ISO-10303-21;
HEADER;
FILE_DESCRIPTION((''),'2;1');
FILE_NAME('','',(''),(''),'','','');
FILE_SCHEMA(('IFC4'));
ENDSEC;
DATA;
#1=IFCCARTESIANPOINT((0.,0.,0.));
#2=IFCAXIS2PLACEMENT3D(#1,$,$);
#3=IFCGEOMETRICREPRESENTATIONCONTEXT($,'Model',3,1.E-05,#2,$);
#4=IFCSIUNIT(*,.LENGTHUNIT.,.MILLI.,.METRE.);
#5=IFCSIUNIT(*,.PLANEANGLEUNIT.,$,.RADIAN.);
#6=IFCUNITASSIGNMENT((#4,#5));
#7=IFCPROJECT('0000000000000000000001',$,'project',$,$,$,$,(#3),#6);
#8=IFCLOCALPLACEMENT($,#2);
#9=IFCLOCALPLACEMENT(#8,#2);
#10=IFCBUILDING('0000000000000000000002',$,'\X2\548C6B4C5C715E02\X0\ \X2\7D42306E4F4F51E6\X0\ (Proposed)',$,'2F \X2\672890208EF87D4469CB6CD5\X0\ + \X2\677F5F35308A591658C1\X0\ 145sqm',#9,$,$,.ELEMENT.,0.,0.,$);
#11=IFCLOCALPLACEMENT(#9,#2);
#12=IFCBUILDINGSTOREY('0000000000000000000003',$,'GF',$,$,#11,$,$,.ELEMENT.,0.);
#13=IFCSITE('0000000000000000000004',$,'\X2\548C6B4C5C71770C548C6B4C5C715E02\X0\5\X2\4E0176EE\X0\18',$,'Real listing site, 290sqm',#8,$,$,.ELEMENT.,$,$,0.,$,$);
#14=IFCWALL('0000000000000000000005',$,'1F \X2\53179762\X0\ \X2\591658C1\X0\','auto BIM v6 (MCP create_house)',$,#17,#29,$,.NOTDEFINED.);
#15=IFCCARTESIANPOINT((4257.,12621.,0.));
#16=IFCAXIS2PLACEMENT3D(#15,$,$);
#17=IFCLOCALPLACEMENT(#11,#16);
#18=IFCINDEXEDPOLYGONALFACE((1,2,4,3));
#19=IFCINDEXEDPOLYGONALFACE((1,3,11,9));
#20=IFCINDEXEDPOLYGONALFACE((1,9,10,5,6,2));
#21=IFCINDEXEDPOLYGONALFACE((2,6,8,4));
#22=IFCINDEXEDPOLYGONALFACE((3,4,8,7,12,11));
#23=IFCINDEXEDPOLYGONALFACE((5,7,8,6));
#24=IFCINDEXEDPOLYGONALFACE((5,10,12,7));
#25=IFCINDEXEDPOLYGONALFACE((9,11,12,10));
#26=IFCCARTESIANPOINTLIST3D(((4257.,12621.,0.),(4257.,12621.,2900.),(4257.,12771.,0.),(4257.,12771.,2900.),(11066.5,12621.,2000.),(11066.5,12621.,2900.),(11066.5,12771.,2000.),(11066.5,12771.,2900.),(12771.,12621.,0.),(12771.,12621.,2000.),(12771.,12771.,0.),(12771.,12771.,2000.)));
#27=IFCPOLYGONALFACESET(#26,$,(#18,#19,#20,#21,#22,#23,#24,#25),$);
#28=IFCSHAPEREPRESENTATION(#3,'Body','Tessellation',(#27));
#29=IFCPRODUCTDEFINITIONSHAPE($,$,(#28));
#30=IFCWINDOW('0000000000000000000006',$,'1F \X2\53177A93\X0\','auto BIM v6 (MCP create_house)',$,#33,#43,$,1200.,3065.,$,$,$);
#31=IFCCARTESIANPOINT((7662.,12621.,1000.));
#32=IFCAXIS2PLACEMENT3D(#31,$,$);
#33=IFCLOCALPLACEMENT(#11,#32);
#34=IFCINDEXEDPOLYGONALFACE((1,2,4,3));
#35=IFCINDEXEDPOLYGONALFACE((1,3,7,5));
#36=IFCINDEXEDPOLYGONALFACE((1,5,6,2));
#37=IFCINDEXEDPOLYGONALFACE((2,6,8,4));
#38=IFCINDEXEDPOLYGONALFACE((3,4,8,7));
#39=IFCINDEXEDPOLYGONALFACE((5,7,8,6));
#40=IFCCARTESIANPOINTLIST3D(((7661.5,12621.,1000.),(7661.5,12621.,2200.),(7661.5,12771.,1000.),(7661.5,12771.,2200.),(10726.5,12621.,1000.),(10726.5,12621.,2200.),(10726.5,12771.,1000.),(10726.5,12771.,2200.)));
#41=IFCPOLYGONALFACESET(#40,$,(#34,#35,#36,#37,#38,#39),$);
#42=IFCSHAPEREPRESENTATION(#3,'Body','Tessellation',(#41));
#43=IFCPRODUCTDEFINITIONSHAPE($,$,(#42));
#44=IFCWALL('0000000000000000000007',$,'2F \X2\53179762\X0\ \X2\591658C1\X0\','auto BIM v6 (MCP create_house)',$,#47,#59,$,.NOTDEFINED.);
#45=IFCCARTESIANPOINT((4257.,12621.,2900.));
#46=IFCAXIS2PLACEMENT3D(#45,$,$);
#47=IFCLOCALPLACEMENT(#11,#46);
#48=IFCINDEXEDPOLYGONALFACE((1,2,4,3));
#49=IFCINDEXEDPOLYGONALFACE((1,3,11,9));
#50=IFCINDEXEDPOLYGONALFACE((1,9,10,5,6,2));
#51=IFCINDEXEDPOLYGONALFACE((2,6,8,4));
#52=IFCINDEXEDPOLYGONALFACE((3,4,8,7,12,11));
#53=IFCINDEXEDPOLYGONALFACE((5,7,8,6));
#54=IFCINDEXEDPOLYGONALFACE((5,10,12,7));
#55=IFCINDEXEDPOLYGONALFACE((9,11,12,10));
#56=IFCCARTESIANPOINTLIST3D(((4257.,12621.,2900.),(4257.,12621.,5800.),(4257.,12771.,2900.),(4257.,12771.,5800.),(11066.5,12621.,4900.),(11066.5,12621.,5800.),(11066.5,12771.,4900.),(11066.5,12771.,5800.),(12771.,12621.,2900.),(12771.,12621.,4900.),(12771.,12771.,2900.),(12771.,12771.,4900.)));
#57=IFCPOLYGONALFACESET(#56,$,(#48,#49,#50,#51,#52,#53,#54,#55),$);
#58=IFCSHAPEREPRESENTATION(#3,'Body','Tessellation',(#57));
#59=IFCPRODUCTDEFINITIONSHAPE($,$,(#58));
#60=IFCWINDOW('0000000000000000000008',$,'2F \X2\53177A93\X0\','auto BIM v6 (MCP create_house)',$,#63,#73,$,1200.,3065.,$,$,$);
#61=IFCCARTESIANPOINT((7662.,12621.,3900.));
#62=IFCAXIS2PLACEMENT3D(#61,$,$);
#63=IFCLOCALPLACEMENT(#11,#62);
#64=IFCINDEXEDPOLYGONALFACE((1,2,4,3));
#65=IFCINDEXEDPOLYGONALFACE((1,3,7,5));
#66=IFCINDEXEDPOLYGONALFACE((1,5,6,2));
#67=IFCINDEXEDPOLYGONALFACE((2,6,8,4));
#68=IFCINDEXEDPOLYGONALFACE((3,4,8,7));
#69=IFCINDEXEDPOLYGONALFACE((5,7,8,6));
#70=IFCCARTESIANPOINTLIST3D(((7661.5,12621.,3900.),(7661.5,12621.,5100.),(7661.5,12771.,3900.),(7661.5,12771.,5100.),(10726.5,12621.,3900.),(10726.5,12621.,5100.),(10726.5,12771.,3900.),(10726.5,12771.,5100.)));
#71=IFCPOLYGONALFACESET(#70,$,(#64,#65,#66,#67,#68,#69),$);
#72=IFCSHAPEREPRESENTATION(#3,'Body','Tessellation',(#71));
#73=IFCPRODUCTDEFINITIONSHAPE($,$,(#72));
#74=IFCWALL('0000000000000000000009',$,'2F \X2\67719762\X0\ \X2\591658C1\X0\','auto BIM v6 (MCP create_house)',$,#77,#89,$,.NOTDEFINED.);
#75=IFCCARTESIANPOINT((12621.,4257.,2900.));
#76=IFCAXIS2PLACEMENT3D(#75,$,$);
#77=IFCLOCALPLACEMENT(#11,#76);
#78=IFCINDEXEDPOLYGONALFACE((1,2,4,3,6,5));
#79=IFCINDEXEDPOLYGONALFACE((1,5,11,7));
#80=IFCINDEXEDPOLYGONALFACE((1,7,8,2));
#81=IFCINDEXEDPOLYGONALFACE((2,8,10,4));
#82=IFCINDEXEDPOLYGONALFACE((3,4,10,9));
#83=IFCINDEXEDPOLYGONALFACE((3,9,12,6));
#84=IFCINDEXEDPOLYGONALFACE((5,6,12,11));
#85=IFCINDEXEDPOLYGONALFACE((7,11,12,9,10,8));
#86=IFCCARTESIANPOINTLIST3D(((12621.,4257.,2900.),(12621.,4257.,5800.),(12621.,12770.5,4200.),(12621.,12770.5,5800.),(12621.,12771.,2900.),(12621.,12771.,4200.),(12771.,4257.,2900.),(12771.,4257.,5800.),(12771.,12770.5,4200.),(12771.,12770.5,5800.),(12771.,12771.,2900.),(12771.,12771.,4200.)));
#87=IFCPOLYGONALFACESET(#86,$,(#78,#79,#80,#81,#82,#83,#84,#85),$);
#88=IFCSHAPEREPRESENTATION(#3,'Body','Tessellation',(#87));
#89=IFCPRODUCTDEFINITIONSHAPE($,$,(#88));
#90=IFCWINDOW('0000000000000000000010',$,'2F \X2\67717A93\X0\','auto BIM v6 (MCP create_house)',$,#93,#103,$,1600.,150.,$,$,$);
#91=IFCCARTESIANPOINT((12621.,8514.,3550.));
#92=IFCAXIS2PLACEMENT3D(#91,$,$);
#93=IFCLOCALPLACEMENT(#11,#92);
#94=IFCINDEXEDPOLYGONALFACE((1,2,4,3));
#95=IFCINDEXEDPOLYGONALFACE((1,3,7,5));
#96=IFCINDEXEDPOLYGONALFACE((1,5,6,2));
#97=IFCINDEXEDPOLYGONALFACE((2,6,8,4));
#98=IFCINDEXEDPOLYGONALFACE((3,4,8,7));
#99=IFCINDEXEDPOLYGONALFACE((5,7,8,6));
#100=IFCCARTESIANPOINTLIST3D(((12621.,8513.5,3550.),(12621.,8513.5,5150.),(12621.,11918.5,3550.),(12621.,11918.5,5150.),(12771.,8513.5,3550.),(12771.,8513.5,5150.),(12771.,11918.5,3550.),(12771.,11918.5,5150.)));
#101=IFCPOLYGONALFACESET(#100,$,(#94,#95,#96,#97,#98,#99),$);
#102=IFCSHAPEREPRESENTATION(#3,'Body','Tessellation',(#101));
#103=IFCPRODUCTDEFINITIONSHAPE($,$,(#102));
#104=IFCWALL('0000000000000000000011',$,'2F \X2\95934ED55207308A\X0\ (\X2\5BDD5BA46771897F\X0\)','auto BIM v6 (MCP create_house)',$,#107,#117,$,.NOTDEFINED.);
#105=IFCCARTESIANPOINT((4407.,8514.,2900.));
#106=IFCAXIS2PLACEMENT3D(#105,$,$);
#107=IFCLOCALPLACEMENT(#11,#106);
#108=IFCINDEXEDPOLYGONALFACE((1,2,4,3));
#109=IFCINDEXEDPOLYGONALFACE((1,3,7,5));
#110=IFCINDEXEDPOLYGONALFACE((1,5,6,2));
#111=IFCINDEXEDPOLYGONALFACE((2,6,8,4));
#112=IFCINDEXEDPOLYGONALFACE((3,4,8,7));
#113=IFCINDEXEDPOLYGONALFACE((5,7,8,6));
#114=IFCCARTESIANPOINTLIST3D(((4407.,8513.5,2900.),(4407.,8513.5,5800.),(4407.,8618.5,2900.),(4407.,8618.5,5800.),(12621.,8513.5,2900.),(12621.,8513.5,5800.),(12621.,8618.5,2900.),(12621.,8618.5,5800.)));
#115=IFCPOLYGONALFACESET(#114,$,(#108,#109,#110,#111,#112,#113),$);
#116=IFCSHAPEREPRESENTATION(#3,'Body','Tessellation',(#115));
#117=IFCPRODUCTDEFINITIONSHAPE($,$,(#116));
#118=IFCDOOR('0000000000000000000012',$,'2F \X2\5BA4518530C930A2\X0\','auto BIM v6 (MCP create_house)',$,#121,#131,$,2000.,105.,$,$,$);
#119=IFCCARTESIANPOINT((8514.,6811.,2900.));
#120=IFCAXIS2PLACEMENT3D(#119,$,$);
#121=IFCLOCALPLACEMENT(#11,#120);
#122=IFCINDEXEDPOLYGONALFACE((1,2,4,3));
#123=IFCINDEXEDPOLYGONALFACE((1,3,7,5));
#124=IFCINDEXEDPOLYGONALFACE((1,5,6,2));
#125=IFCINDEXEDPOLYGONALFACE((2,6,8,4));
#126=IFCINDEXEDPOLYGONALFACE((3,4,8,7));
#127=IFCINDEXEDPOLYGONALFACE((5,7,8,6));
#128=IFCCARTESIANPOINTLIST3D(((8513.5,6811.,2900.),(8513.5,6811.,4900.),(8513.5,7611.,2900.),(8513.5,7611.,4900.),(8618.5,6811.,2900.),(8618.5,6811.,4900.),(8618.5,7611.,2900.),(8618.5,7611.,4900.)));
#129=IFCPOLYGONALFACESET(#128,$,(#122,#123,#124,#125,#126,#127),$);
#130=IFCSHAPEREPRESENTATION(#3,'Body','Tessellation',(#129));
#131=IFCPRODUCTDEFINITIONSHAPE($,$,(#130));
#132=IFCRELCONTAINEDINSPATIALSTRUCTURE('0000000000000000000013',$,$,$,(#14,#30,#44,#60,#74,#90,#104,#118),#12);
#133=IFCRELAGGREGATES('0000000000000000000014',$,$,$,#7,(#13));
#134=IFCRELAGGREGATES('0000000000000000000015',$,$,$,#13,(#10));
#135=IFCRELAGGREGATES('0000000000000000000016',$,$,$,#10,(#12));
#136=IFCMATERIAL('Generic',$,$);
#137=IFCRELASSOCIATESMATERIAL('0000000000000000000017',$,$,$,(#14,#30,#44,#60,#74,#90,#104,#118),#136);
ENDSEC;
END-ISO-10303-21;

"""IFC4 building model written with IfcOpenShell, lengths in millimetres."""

from ifc_helpers import new_model, si_unit, frame, frame_2d, origin, place, context, project, spatial, rectangle, extrude, material, element, fill, save


model = new_model("IFC4")

# Units and contexts
model_context = context("Model", 3, precision=1e-05, world=origin())
ifc_project = project(units=[si_unit("LENGTHUNIT", "METRE", prefix="MILLI"), si_unit("PLANEANGLEUNIT", "RADIAN")], contexts=[model_context])

# Site, building, storey
site_placement = place(None, origin())
site = spatial("IfcSite", under=ifc_project, at=site_placement, Name="和歌山県和歌山市5丁目18", ObjectType="Real listing site, 290sqm", CompositionType="ELEMENT", RefElevation=0.0)
building_placement = place(site_placement, origin())
building = spatial("IfcBuilding", under=site, at=building_placement, Name="和歌山市 終の住処 (Proposed)", ObjectType="2F 木造軸組構法 + 板張り外壁 145sqm", CompositionType="ELEMENT", ElevationOfRefHeight=0.0, ElevationOfTerrain=0.0)
storey_placement = place(building_placement, origin())
storey = spatial("IfcBuildingStorey", under=building, at=storey_placement, Name="GF", CompositionType="ELEMENT", Elevation=0.0)

# Wall, opening, window
ifc_material = material(Name="Generic")
wall_1_placement = place(storey_placement, frame((4257.0, 12621.0, 0.0)))
wall_1 = element("IfcWall", 1, at=wall_1_placement, inside=storey, material=ifc_material, Name="1F 北面 外壁", Description="auto BIM v6 (MCP create_house)", PredefinedType="NOTDEFINED", context=model_context, shape_type="SweptSolid", body=[
    extrude(rectangle(XDim=8514.0, YDim=150.0, at=frame_2d((4257.0, 75.0))), frame((4257.0, 12621.0, 0.0)), (0.0, 0.0, 1.0), 2900.0),
])
opening_1_placement = place(storey_placement, frame((7662.0, 12621.0, 1000.0)))
opening_1 = element("IfcOpeningElement", 2, at=opening_1_placement, cuts=wall_1, PredefinedType="NOTDEFINED", context=model_context, shape_type="SweptSolid", body=[
    extrude(rectangle(XDim=3065.0, YDim=150.0, at=frame_2d((1532.0, 75.0))), frame((7662.0, 12621.0, 1000.0)), (0.0, 0.0, 1.0), 1200.0),
])
window_1_placement = place(storey_placement, frame((7662.0, 12621.0, 1000.0)))
window_1 = element("IfcWindow", 3, at=window_1_placement, inside=storey, material=ifc_material, Name="1F 北窓", Description="auto BIM v6 (MCP create_house)", OverallHeight=1200.0, OverallWidth=3065.0, context=model_context, shape_type="SweptSolid", body=[
    extrude(rectangle(XDim=3065.0, YDim=150.0, at=frame_2d((1532.0, 75.0))), frame((7662.0, 12621.0, 1000.0)), (0.0, 0.0, 1.0), 1200.0),
])
fill(opening_1, window_1)

# Walls, openings, windows
wall_2_placement = place(storey_placement, frame((4257.0, 12621.0, 2900.0)))
wall_2 = element("IfcWall", 4, at=wall_2_placement, inside=storey, material=ifc_material, Name="2F 北面 外壁", Description="auto BIM v6 (MCP create_house)", PredefinedType="NOTDEFINED", context=model_context, shape_type="SweptSolid", body=[
    extrude(rectangle(XDim=8514.0, YDim=150.0, at=frame_2d((4257.0, 75.0))), frame((4257.0, 12621.0, 2900.0)), (0.0, 0.0, 1.0), 2900.0),
])
opening_2_placement = place(storey_placement, frame((7662.0, 12621.0, 3900.0)))
opening_2 = element("IfcOpeningElement", 5, at=opening_2_placement, cuts=wall_2, PredefinedType="NOTDEFINED", context=model_context, shape_type="SweptSolid", body=[
    extrude(rectangle(XDim=3065.0, YDim=150.0, at=frame_2d((1532.0, 75.0))), frame((7662.0, 12621.0, 3900.0)), (0.0, 0.0, 1.0), 1200.0),
])
window_2_placement = place(storey_placement, frame((7662.0, 12621.0, 3900.0)))
window_2 = element("IfcWindow", 6, at=window_2_placement, inside=storey, material=ifc_material, Name="2F 北窓", Description="auto BIM v6 (MCP create_house)", OverallHeight=1200.0, OverallWidth=3065.0, context=model_context, shape_type="SweptSolid", body=[
    extrude(rectangle(XDim=3065.0, YDim=150.0, at=frame_2d((1532.0, 75.0))), frame((7662.0, 12621.0, 3900.0)), (0.0, 0.0, 1.0), 1200.0),
])
fill(opening_2, window_2)
wall_3_placement = place(storey_placement, frame((12621.0, 4257.0, 2900.0)))
wall_3 = element("IfcWall", 7, at=wall_3_placement, inside=storey, material=ifc_material, Name="2F 東面 外壁", Description="auto BIM v6 (MCP create_house)", PredefinedType="NOTDEFINED", context=model_context, shape_type="SweptSolid", body=[
    extrude(rectangle(XDim=150.0, YDim=8514.0, at=frame_2d((75.0, 4257.0))), frame((12621.0, 4257.0, 2900.0)), (0.0, 0.0, 1.0), 2900.0),
])
opening_3_placement = place(storey_placement, frame((12621.0, 8514.0, 3550.0)))
opening_3 = element("IfcOpeningElement", 8, at=opening_3_placement, cuts=wall_3, PredefinedType="NOTDEFINED", context=model_context, shape_type="SweptSolid", body=[
    extrude(rectangle(XDim=150.0, YDim=3405.0, at=frame_2d((75.0, 1702.0))), frame((12621.0, 8514.0, 3550.0)), (0.0, 0.0, 1.0), 1600.0),
])
window_3_placement = place(storey_placement, frame((12621.0, 8514.0, 3550.0)))
window_3 = element("IfcWindow", 9, at=window_3_placement, inside=storey, material=ifc_material, Name="2F 東窓", Description="auto BIM v6 (MCP create_house)", OverallHeight=1600.0, OverallWidth=150.0, context=model_context, shape_type="SweptSolid", body=[
    extrude(rectangle(XDim=150.0, YDim=3405.0, at=frame_2d((75.0, 1702.0))), frame((12621.0, 8514.0, 3550.0)), (0.0, 0.0, 1.0), 1600.0),
])
fill(opening_3, window_3)

# Wall
wall_4_placement = place(storey_placement, frame((4407.0, 8514.0, 2900.0)))
element("IfcWall", 10, at=wall_4_placement, inside=storey, material=ifc_material, Name="2F 間仕切り (寝室東西)", Description="auto BIM v6 (MCP create_house)", PredefinedType="NOTDEFINED", context=model_context, shape_type="SweptSolid", body=[
    extrude(rectangle(XDim=8214.0, YDim=105.0, at=frame_2d((4107.0, 52.0))), frame((4407.0, 8514.0, 2900.0)), (0.0, 0.0, 1.0), 2900.0),
])

# Door
door_placement = place(storey_placement, frame((8514.0, 6811.0, 2900.0)))
element("IfcDoor", 11, at=door_placement, inside=storey, material=ifc_material, Name="2F 室内ドア", Description="auto BIM v6 (MCP create_house)", OverallHeight=2000.0, OverallWidth=105.0, context=model_context, shape_type="SweptSolid", body=[
    extrude(rectangle(XDim=105.0, YDim=800.0, at=frame_2d((52.0, 400.0))), frame((8514.0, 6811.0, 2900.0)), (0.0, 0.0, 1.0), 2000.0),
])

save(model, "model.ifc")
